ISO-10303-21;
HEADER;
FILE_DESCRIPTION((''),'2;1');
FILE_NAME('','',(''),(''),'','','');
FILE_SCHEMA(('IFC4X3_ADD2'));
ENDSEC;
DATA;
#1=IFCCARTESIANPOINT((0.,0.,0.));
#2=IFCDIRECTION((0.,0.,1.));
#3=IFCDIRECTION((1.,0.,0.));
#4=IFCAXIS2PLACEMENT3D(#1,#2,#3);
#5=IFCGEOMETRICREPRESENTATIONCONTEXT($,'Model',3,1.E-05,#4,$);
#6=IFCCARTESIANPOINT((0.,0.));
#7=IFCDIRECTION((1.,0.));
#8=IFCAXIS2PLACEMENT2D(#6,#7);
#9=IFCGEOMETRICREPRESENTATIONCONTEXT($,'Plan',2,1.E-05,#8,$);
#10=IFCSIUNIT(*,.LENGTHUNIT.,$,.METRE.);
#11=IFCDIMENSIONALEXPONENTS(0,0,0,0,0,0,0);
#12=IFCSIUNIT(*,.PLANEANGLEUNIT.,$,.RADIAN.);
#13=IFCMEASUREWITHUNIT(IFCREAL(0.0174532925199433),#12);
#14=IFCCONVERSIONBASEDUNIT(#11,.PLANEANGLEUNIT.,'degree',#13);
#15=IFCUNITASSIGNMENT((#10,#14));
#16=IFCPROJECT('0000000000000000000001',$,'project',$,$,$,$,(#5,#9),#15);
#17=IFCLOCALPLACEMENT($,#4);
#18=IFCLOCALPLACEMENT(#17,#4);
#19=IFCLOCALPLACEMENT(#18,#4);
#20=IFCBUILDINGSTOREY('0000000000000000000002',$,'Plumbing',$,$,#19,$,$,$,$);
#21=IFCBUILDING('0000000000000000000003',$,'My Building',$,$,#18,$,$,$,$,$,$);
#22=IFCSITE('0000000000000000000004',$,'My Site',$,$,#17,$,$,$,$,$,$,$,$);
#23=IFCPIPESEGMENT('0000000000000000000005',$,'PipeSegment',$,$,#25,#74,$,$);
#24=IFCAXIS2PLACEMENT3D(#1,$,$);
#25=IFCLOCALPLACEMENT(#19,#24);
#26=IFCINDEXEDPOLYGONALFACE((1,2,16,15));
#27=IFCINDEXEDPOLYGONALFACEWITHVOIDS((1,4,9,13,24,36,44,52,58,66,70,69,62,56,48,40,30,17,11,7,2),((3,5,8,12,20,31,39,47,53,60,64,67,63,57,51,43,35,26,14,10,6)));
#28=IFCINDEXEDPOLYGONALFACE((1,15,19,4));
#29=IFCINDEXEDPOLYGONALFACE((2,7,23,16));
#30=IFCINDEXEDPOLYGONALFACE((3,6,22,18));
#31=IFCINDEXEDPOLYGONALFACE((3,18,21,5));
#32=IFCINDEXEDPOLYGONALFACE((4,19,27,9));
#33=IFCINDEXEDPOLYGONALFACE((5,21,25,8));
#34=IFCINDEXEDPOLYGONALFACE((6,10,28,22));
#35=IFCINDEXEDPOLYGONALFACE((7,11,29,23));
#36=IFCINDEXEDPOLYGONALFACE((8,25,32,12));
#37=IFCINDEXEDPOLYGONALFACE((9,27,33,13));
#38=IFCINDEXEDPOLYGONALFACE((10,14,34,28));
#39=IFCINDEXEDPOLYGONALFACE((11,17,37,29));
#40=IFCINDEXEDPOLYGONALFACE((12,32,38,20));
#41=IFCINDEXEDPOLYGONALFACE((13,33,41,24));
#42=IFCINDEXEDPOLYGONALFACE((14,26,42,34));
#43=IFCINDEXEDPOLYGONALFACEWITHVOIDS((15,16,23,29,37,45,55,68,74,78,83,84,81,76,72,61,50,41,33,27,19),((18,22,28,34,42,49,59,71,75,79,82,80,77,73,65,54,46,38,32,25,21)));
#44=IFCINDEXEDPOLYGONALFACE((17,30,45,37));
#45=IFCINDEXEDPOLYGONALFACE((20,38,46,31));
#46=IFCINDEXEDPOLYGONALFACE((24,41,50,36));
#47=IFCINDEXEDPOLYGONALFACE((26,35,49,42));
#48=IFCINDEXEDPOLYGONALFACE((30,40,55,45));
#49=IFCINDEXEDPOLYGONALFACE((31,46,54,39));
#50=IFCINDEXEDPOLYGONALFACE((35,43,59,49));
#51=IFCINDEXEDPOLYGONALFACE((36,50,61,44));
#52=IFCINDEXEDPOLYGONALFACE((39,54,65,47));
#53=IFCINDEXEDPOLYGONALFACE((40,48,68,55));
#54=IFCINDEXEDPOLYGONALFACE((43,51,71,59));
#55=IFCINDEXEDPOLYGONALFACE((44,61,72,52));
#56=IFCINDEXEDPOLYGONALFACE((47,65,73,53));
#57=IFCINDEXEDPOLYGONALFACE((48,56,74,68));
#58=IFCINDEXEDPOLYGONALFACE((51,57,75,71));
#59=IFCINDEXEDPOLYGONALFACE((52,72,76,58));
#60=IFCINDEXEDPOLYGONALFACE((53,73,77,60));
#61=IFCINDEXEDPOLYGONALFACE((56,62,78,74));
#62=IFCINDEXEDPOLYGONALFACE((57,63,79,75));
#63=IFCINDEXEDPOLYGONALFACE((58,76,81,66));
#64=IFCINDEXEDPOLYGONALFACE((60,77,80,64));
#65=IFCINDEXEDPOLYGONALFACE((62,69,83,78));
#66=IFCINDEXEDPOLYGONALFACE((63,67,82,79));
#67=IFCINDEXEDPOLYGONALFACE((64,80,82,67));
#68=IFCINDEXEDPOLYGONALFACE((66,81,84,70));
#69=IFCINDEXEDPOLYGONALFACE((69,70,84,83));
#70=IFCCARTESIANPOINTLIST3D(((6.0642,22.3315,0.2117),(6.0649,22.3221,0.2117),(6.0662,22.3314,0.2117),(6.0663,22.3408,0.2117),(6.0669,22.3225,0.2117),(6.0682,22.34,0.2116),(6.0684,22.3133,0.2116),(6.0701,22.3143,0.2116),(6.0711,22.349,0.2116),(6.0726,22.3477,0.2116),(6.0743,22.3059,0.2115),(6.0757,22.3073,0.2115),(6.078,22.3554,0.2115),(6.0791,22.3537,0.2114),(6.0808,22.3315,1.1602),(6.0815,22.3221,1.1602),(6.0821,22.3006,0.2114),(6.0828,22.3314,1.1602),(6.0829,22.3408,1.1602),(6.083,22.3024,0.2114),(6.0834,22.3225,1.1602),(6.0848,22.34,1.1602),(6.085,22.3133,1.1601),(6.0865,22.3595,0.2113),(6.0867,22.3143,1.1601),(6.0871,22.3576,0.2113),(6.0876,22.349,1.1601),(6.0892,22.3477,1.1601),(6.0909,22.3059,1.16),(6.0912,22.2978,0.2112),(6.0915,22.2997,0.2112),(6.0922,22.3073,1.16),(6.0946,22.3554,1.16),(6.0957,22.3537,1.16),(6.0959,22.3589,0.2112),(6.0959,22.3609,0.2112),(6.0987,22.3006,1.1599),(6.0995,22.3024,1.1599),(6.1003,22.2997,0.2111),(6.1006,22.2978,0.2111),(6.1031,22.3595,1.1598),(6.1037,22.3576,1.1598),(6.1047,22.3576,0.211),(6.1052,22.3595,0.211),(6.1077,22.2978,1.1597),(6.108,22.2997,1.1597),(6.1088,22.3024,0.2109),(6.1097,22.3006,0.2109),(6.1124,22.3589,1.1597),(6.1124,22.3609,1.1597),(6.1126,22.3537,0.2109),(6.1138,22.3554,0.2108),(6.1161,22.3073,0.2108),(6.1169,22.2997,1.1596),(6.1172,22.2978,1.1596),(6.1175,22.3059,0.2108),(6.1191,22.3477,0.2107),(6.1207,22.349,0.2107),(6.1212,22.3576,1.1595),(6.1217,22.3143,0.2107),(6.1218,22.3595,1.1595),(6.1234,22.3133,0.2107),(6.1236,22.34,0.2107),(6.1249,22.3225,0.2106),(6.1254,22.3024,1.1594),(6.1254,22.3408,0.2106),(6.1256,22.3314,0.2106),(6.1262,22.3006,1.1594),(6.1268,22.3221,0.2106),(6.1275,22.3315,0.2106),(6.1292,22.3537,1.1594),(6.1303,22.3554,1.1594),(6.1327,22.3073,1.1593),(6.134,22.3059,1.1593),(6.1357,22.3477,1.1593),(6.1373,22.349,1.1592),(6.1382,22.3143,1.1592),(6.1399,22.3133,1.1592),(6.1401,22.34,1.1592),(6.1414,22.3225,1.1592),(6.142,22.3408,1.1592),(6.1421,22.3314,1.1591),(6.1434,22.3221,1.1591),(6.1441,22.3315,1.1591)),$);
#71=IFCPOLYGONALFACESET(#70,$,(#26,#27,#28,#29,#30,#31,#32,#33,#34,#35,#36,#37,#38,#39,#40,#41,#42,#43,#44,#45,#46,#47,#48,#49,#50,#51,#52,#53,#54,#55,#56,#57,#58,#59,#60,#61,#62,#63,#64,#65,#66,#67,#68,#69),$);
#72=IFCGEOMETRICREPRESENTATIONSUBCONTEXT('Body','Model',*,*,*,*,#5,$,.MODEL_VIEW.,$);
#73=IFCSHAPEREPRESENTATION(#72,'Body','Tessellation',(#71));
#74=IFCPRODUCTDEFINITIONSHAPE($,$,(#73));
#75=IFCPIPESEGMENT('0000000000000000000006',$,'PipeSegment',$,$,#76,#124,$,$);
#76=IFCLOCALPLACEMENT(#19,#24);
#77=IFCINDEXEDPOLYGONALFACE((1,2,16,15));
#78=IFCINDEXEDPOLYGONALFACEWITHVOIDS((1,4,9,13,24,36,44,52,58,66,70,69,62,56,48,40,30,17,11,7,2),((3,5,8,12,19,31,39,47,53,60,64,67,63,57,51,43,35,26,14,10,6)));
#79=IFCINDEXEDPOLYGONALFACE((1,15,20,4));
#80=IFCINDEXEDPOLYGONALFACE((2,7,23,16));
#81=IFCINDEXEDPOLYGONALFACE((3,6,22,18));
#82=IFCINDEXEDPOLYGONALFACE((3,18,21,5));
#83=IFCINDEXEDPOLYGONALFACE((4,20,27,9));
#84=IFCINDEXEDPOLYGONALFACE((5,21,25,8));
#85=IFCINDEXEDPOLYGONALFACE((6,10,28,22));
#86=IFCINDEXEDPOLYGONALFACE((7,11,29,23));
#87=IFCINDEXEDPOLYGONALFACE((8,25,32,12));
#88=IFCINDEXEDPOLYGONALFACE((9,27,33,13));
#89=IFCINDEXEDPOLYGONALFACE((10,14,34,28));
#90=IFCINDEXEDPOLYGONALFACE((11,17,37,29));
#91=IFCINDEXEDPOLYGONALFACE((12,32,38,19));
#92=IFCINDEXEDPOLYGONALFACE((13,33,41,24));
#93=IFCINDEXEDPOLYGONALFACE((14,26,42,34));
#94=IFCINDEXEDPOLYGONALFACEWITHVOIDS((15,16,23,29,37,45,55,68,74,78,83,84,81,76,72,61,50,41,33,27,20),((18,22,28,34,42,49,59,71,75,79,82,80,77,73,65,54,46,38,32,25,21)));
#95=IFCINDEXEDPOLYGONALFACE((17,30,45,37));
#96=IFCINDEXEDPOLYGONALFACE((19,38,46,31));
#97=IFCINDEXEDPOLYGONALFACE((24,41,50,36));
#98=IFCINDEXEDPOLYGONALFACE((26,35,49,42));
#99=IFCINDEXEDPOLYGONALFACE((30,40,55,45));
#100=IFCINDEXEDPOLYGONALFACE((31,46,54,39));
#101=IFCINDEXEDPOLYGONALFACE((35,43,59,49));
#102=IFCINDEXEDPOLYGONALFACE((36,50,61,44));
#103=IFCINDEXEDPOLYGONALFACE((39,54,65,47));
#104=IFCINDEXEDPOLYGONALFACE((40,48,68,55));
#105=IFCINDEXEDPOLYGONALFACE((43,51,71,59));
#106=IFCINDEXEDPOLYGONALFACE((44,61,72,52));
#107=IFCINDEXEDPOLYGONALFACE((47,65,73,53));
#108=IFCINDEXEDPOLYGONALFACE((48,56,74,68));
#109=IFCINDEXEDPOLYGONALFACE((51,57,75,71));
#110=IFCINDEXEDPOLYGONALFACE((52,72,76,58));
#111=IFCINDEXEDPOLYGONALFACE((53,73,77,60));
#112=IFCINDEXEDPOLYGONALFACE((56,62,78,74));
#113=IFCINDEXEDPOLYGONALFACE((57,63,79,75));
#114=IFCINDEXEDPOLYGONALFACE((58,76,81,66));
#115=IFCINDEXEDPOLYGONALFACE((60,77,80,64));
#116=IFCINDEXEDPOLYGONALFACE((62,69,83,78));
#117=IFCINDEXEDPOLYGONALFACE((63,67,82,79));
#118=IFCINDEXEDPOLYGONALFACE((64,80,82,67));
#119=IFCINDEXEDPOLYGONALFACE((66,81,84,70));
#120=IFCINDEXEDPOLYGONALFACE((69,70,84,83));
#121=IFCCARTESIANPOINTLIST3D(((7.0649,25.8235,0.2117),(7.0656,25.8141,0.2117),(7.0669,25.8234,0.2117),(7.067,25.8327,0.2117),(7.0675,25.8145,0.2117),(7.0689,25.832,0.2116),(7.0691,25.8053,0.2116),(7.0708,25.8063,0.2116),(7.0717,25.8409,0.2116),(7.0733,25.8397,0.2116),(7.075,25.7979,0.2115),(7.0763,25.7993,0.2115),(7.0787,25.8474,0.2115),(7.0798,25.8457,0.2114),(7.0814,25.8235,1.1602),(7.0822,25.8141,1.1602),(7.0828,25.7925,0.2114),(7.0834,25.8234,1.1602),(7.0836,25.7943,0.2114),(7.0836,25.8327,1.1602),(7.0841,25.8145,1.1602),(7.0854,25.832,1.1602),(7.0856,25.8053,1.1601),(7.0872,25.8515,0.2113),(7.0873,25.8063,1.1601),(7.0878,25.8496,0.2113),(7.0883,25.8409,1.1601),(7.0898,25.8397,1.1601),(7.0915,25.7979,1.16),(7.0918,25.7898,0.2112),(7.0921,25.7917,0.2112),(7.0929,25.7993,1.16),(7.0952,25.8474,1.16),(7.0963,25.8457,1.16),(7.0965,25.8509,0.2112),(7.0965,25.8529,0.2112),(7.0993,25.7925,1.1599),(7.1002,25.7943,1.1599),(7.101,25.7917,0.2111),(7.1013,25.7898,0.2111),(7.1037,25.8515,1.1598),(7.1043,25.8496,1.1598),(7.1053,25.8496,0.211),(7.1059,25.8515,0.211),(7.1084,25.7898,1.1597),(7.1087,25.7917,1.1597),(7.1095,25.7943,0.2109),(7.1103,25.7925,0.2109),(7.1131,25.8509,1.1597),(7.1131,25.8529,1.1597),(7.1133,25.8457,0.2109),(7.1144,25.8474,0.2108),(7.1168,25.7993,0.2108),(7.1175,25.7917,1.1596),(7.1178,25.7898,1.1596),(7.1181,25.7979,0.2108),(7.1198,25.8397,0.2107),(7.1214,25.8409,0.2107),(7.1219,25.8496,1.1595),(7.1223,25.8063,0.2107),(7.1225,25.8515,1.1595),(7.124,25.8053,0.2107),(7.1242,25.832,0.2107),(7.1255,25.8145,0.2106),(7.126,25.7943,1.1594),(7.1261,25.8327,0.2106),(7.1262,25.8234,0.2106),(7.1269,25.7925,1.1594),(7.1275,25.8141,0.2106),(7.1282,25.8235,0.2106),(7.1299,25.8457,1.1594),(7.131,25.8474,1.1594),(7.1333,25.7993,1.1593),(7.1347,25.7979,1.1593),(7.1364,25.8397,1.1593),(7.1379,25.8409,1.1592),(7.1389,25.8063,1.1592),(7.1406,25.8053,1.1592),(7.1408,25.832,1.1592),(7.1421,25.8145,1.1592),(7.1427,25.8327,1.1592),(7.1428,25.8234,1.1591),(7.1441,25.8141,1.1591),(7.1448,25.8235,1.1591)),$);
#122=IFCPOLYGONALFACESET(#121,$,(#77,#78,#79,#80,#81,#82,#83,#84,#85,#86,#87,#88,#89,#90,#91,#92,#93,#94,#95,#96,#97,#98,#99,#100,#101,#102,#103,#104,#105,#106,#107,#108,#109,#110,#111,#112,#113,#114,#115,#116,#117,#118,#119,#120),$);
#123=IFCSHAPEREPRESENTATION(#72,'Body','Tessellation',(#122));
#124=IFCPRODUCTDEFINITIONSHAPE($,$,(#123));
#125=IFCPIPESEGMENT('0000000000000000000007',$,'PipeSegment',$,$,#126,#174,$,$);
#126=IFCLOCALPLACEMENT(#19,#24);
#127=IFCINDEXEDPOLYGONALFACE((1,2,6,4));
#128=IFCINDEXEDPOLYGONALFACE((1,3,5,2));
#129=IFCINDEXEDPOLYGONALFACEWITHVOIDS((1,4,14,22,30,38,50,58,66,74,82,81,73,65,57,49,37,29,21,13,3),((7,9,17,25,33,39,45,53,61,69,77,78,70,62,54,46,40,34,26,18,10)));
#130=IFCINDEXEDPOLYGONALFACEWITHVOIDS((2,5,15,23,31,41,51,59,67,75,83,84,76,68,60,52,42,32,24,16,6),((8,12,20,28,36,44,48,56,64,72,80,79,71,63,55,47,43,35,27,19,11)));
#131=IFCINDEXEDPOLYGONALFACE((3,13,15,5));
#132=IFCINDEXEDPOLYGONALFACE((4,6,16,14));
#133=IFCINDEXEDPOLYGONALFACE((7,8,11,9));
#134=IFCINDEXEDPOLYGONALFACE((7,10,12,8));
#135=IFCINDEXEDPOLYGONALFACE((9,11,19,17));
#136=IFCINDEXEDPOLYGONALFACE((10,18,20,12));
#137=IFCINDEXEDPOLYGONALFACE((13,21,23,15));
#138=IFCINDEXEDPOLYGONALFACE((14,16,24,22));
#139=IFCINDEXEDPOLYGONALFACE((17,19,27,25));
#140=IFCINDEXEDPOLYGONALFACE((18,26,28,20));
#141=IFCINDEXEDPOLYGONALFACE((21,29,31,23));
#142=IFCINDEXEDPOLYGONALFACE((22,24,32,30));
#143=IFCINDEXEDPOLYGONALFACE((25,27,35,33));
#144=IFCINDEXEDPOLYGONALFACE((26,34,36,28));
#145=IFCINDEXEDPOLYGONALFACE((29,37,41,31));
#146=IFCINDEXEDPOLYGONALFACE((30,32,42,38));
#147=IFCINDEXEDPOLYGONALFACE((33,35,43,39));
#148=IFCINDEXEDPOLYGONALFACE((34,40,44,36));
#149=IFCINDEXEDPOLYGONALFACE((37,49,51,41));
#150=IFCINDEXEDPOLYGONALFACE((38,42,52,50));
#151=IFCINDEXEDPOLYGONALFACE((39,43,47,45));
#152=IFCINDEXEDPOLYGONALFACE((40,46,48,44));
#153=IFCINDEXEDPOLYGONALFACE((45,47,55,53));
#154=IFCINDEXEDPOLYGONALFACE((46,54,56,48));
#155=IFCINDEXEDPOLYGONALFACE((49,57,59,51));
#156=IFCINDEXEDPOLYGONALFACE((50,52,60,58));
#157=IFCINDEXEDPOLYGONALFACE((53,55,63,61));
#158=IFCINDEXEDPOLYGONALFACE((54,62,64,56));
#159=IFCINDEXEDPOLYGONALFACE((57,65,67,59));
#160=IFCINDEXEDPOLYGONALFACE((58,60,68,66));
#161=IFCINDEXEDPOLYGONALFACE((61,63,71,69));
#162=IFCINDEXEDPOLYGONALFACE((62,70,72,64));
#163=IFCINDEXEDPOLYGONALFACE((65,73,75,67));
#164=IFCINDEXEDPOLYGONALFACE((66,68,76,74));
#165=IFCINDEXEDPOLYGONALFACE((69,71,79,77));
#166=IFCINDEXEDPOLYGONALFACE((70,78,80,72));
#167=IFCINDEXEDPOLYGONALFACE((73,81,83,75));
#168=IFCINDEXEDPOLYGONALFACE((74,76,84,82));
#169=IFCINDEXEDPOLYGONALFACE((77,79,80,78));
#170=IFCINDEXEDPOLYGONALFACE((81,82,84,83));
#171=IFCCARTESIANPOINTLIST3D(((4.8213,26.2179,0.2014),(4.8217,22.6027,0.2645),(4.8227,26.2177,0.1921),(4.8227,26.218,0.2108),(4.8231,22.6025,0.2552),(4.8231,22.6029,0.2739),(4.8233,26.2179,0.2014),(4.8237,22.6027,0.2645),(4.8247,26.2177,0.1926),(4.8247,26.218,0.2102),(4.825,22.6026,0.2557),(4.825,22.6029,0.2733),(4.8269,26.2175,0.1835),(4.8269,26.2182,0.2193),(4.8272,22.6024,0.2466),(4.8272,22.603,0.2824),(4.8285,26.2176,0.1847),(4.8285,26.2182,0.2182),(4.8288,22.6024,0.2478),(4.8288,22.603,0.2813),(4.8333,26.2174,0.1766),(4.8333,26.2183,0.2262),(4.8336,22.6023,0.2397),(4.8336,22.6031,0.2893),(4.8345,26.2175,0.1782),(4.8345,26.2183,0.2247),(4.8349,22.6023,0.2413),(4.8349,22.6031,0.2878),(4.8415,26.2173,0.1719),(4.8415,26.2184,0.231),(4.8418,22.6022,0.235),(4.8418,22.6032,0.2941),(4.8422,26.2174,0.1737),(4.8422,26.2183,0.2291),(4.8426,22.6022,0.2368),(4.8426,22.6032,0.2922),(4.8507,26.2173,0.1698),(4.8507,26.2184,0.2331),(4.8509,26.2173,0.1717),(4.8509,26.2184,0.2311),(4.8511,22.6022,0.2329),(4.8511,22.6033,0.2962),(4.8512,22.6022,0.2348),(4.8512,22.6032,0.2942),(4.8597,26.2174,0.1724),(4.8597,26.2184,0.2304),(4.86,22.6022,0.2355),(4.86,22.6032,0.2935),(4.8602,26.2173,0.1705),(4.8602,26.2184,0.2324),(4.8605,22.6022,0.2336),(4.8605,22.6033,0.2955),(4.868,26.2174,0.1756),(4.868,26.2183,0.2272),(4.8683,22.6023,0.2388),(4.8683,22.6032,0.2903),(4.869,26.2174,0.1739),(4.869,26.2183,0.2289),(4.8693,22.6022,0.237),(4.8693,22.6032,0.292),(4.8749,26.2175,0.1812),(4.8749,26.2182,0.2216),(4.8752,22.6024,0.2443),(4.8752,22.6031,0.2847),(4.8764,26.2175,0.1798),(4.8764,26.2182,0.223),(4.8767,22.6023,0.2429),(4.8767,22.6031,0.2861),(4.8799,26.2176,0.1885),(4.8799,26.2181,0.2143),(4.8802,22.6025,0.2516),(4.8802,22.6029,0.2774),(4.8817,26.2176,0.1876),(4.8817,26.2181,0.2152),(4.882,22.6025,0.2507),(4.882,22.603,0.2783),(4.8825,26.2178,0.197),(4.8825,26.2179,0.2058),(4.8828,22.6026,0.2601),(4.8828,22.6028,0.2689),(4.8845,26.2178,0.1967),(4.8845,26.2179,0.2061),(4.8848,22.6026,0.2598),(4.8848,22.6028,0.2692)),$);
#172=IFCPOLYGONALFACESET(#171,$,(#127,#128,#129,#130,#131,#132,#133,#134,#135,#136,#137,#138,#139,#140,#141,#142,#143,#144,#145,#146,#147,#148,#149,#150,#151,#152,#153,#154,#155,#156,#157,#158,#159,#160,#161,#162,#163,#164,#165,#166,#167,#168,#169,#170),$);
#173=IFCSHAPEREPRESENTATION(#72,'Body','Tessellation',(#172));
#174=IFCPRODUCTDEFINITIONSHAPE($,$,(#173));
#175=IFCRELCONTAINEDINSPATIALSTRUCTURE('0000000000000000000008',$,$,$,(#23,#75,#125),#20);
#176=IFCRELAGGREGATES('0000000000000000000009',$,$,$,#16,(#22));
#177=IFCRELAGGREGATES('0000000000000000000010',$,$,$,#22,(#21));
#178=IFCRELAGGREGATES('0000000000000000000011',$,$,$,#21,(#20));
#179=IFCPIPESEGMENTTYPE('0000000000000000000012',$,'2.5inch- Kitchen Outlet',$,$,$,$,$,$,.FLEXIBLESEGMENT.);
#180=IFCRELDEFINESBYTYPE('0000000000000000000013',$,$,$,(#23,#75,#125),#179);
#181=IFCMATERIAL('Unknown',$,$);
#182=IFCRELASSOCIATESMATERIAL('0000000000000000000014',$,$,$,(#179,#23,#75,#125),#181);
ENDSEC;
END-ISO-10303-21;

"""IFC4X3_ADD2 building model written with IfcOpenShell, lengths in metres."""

from ifc_helpers import new_model, entity, si_unit, converted_unit, frame, origin_with_axes, origin_2d_with_axis, place, context, subcontext, project, spatial, hollow_circle, extrude, material, material_profile, profile_set, profile_usage, type_object, element, save


model = new_model("IFC4X3_ADD2")

# Units and contexts
model_context = context("Model", 3, precision=1e-05, world=origin_with_axes())
plan_context = context("Plan", 2, precision=1e-05, world=origin_2d_with_axis())
body_context = subcontext(model_context, "Body", "Model", "MODEL_VIEW")
ifc_project = project(units=[si_unit("LENGTHUNIT", "METRE"), converted_unit("PLANEANGLEUNIT", "degree", entity("IfcReal", 0.0174532925199433), si_unit("PLANEANGLEUNIT", "RADIAN"), dimensions=[0, 0, 0, 0, 0, 0, 0])], contexts=[model_context, plan_context])

# Site, building, storey
site_placement = place(None, origin_with_axes())
site = spatial("IfcSite", under=ifc_project, at=site_placement, Name="My Site")
building_placement = place(site_placement, origin_with_axes())
building = spatial("IfcBuilding", under=site, at=building_placement, Name="My Building")
storey_placement = place(building_placement, origin_with_axes())
storey = spatial("IfcBuildingStorey", under=building, at=storey_placement, Name="Plumbing")

# Pipe segments
ifc_material_1 = material(Name="Unknown")
ifc_material_profile_1 = material_profile(ifc_material_1, hollow_circle(Radius=0.0318, WallThickness=0.002))
ifc_profile_set_1 = profile_set([ifc_material_profile_1], Name="kitchenwater")
ifc_material_profile_2 = material_profile(ifc_material_1, hollow_circle(Radius=0.0318, WallThickness=0.002))
ifc_profile_set_2 = profile_set([ifc_material_profile_2], Name="kitchenwater")
pipe_segment_type_1 = type_object("IfcPipeSegmentType", Name="2.5inch- Kitchen Outlet", PredefinedType="FLEXIBLESEGMENT", material=ifc_profile_set_2)
ifc_profile_usage_1 = profile_usage(ifc_profile_set_1)
pipe_segment_1_placement = place(storey_placement, frame((6.0959, 22.3292, 0.2112), z_axis=(0.017452, 0.0, 0.999848), x_axis=(0.0, 1.0, 0.0)))
element("IfcPipeSegment", 1, at=pipe_segment_1_placement, inside=storey, type_object=pipe_segment_type_1, material=ifc_profile_usage_1, Name="PipeSegment", context=body_context, shape_type="SweptSolid", body=[
    extrude(hollow_circle(Radius=0.0318, WallThickness=0.002), origin_with_axes(), (0.0, 0.0, 1.0), 0.9487),
])
ifc_profile_usage_2 = profile_usage(ifc_profile_set_1)
pipe_segment_2_placement = place(storey_placement, frame((7.0965, 25.8211, 0.2112), z_axis=(0.017452, 0.0, 0.999848), x_axis=(0.0, 1.0, 0.0)))
element("IfcPipeSegment", 2, at=pipe_segment_2_placement, inside=storey, type_object=pipe_segment_type_1, material=ifc_profile_usage_2, Name="PipeSegment", context=body_context, shape_type="SweptSolid", body=[
    extrude(hollow_circle(Radius=0.0318, WallThickness=0.002), origin_with_axes(), (0.0, 0.0, 1.0), 0.9487),
])
ifc_profile_usage_3 = profile_usage(ifc_profile_set_1)
pipe_segment_3_placement = place(storey_placement, frame((4.8534, 22.6027, 0.2645), z_axis=(-0.000094, 0.999848, -0.017452), x_axis=(-1.0, -0.000094, 0.0)))
element("IfcPipeSegment", 3, at=pipe_segment_3_placement, inside=storey, type_object=pipe_segment_type_1, material=ifc_profile_usage_3, Name="PipeSegment", context=body_context, shape_type="SweptSolid", body=[
    extrude(hollow_circle(Radius=0.0318, WallThickness=0.002), origin_with_axes(), (0.0, 0.0, 1.0), 3.6157),
])

save(model, "model.ifc")
